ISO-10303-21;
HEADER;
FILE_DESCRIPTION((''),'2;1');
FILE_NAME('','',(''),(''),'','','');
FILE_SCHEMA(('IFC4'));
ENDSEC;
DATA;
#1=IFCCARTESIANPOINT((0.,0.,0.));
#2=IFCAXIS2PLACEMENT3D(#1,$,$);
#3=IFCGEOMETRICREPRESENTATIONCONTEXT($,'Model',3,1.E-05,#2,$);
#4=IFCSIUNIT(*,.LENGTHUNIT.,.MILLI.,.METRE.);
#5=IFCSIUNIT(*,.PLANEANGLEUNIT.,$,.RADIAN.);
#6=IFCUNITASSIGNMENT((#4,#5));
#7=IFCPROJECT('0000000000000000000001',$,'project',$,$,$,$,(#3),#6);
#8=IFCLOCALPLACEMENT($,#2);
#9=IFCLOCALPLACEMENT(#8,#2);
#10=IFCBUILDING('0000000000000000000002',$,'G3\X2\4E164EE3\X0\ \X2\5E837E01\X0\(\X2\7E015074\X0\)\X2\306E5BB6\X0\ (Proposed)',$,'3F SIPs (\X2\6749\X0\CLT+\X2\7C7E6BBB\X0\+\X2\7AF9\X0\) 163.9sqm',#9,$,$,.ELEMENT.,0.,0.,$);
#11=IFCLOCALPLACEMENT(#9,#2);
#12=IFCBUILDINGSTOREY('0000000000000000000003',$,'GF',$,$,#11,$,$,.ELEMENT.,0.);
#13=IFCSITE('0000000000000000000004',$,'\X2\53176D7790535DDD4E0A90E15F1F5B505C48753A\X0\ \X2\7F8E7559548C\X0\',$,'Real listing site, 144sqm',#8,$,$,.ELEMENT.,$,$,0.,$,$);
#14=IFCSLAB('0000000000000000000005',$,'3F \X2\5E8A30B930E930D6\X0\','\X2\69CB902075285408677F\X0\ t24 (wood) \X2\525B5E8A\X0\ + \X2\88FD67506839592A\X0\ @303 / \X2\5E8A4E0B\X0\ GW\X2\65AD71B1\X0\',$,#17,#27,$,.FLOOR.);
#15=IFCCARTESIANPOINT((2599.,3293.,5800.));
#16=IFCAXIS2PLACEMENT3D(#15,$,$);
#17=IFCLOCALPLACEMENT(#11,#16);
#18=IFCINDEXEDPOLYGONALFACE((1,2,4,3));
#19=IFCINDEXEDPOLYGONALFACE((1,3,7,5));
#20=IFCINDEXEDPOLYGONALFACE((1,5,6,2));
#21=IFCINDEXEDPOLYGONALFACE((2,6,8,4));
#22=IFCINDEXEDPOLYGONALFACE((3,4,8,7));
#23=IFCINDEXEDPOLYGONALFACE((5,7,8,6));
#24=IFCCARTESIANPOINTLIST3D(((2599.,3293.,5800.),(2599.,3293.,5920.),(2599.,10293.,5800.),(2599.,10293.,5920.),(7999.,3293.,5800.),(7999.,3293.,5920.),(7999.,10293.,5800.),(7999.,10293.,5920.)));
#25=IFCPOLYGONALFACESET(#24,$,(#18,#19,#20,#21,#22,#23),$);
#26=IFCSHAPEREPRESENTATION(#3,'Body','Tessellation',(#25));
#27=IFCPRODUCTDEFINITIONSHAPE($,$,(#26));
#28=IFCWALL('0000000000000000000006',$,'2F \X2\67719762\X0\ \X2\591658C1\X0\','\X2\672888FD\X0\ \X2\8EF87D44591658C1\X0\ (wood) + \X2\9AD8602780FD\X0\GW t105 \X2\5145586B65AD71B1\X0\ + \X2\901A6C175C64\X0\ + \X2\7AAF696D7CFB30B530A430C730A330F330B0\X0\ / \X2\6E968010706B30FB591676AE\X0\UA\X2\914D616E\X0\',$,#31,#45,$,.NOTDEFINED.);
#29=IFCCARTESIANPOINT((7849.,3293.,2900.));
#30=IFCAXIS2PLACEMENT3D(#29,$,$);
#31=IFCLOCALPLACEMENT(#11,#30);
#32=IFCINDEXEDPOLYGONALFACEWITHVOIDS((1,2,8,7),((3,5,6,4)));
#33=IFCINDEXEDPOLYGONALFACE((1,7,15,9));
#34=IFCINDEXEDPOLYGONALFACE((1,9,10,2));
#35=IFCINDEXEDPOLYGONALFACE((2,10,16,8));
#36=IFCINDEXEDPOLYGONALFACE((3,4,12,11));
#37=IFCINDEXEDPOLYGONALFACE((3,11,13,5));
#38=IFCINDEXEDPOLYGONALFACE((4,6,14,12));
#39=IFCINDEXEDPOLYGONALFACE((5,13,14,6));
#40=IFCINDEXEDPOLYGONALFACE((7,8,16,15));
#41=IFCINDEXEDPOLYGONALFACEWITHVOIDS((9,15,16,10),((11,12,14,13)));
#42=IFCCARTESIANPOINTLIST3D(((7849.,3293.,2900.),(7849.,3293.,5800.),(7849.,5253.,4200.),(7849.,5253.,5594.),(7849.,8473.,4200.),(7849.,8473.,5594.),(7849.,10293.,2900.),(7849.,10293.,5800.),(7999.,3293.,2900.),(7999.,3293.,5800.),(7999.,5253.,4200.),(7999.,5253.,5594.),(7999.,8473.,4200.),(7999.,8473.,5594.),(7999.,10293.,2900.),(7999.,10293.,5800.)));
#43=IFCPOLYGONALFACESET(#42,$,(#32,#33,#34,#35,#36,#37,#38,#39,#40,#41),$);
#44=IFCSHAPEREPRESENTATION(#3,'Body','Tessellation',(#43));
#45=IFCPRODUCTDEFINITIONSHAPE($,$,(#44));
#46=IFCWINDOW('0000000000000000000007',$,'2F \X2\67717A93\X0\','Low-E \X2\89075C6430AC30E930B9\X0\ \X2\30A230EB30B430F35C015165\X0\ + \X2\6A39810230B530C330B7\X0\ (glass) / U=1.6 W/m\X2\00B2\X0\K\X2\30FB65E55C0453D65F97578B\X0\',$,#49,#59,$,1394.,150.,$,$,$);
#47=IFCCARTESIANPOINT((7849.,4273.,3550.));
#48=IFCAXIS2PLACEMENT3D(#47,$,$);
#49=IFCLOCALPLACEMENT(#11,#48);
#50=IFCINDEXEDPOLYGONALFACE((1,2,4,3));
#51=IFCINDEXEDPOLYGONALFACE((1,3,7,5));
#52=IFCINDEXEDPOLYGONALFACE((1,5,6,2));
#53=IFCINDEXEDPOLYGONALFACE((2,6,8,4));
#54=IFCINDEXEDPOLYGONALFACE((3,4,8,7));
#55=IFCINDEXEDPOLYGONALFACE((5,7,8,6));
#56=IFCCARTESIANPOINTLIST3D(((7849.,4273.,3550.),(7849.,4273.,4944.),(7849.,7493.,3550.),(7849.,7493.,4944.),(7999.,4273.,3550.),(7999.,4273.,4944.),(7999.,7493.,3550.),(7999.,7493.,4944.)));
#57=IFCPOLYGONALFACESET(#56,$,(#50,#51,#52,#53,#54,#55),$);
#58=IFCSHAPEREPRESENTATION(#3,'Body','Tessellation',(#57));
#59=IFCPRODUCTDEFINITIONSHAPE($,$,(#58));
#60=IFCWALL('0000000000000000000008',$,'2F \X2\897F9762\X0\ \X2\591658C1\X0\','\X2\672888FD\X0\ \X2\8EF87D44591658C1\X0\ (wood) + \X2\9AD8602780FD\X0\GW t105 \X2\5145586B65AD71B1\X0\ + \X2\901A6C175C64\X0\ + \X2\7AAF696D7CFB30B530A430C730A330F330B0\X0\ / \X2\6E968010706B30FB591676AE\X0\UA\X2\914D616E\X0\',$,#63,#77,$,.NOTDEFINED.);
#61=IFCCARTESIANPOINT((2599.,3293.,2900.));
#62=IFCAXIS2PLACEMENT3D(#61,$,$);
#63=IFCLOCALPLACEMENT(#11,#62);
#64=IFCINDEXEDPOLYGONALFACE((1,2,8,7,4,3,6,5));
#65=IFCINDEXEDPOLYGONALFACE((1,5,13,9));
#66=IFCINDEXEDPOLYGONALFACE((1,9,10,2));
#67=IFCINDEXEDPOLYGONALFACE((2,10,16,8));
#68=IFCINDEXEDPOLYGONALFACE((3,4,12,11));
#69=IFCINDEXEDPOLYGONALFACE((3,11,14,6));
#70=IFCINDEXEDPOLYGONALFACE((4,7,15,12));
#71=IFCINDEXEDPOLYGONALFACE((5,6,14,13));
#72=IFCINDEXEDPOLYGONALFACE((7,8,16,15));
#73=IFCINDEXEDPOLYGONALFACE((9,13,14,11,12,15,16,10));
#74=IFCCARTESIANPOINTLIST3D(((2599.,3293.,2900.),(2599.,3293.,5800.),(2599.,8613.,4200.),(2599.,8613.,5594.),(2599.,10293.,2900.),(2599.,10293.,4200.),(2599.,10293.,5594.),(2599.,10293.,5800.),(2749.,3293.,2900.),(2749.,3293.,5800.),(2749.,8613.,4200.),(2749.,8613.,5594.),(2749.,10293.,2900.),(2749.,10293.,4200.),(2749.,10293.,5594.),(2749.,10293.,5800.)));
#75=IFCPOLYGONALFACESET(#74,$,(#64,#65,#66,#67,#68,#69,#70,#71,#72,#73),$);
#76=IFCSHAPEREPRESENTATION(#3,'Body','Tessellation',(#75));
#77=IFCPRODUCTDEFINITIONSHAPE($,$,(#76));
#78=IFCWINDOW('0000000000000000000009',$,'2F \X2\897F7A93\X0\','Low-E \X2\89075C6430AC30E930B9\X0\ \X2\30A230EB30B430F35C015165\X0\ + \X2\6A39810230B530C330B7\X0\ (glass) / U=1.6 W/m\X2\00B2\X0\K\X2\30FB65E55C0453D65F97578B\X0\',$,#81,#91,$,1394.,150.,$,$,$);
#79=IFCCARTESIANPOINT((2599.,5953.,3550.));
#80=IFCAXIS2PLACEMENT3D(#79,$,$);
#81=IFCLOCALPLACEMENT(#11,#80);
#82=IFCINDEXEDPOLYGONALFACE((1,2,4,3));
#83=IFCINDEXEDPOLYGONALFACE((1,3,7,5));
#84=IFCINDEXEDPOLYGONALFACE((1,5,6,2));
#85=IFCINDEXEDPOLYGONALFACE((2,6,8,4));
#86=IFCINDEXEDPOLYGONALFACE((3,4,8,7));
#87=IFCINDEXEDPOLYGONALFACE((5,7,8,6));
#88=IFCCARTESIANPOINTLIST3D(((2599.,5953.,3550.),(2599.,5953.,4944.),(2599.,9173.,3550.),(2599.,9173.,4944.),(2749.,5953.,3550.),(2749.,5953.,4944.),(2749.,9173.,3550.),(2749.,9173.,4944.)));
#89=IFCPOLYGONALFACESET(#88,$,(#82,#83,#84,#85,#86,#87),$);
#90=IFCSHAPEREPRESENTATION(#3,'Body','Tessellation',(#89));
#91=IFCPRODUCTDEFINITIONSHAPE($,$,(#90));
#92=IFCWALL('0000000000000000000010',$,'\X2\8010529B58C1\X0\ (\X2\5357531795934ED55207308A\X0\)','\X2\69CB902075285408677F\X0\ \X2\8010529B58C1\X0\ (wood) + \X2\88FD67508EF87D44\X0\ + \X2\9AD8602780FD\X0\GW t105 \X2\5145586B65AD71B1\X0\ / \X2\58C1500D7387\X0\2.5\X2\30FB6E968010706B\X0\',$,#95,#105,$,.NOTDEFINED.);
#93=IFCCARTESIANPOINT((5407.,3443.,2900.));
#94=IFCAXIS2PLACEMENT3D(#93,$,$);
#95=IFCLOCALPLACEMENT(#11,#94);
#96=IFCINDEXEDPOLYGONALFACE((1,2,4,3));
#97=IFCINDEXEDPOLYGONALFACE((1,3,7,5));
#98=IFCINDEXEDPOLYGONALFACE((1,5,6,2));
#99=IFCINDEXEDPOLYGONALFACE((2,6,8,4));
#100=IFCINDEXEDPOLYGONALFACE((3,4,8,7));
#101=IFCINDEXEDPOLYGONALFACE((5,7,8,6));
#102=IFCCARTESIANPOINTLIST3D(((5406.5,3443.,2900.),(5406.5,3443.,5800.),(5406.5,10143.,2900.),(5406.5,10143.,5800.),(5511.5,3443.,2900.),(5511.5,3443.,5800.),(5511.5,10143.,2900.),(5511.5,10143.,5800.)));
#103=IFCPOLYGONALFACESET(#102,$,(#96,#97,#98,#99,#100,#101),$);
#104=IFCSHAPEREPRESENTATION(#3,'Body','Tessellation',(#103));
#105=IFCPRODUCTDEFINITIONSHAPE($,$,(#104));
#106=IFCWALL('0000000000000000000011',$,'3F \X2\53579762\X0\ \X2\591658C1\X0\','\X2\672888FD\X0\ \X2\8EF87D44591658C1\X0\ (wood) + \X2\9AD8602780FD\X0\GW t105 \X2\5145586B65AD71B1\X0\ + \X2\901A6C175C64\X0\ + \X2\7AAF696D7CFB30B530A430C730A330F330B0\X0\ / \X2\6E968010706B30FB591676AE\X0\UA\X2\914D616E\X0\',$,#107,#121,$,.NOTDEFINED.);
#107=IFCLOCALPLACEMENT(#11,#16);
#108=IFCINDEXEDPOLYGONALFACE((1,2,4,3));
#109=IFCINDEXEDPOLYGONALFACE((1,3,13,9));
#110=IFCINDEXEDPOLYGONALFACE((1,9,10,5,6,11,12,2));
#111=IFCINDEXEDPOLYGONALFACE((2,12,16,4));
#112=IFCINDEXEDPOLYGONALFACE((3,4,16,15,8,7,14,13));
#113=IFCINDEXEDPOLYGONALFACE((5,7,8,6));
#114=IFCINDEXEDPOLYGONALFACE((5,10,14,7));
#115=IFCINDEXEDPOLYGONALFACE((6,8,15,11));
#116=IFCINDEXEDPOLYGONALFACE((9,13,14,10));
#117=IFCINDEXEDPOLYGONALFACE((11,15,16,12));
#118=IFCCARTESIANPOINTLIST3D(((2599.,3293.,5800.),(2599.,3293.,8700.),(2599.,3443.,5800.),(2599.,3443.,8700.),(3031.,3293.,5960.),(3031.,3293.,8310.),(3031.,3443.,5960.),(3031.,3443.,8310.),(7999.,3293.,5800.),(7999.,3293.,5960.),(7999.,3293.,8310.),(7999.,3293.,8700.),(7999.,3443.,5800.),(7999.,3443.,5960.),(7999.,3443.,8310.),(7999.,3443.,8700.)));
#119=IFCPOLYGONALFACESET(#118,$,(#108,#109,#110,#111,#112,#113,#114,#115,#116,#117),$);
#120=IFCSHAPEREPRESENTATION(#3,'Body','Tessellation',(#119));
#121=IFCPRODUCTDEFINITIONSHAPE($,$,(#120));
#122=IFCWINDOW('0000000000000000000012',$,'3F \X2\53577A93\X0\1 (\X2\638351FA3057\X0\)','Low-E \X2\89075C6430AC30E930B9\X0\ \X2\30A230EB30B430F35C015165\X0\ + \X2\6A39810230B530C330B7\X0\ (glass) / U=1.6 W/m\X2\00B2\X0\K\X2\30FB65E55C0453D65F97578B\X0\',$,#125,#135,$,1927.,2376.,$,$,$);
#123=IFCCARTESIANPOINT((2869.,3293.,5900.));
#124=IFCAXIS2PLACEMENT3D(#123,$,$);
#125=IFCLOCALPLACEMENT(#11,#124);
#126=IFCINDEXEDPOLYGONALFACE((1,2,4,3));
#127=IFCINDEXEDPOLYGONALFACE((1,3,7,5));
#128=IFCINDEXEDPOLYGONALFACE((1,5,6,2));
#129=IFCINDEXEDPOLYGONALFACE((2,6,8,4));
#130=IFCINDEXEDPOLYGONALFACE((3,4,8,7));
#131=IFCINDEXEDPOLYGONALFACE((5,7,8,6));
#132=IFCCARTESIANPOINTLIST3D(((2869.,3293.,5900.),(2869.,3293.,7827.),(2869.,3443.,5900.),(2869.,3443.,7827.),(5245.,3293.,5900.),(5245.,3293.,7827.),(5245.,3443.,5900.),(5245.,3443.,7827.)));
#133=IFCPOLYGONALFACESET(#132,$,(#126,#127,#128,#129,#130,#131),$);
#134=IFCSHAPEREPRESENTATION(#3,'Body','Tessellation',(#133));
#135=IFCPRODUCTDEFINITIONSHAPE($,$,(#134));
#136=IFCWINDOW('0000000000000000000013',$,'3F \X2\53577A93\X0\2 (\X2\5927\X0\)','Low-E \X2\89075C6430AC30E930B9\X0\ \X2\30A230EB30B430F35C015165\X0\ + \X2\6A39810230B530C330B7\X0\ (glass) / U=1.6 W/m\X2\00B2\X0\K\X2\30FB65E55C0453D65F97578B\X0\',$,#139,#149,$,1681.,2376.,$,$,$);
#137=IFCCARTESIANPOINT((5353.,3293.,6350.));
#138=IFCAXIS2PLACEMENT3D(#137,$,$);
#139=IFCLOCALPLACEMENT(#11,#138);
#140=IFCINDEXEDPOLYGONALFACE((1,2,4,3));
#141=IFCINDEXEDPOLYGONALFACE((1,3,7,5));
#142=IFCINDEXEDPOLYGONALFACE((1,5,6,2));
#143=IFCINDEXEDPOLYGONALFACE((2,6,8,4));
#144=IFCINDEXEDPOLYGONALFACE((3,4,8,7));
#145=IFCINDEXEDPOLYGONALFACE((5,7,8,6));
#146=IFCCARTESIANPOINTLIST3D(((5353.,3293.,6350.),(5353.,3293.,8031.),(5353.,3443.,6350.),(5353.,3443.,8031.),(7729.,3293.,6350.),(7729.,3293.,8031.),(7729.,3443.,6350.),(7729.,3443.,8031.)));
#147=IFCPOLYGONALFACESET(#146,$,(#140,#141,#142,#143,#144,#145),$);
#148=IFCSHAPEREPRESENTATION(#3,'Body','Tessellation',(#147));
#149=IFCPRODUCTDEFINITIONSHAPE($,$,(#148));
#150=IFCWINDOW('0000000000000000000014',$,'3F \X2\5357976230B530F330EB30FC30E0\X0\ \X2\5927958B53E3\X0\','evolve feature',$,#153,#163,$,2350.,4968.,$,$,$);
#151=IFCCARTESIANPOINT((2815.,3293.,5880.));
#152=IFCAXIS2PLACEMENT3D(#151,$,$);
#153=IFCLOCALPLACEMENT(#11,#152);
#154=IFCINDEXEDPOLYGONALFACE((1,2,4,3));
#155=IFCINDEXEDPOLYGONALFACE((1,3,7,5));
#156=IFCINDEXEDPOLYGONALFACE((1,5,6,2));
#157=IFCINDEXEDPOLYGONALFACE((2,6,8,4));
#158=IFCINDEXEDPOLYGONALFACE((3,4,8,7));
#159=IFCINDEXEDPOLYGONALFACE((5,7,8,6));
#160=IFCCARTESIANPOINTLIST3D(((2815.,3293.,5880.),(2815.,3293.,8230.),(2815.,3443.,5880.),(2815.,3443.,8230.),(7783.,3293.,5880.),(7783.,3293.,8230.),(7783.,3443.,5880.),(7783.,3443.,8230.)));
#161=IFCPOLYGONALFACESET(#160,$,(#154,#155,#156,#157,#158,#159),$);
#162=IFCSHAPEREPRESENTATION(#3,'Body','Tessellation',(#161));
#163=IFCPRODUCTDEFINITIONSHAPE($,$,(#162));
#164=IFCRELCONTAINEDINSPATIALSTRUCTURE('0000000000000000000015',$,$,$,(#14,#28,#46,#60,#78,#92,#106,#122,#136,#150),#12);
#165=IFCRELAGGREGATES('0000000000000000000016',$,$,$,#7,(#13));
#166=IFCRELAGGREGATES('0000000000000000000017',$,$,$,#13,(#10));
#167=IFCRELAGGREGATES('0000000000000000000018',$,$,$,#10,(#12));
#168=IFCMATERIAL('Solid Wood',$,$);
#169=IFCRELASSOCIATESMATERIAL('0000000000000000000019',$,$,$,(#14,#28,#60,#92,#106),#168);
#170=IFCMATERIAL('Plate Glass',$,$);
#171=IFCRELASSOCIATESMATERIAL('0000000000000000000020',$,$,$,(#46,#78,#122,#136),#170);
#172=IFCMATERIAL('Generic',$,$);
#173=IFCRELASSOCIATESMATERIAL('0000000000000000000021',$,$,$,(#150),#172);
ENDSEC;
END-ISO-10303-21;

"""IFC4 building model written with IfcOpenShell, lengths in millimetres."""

from ifc_helpers import new_model, si_unit, frame, frame_2d, origin, place, context, project, spatial, rectangle, extrude, material, element, fill, save


model = new_model("IFC4")

# Units and contexts
model_context = context("Model", 3, precision=1e-05, world=origin())
ifc_project = project(units=[si_unit("LENGTHUNIT", "METRE", prefix="MILLI"), si_unit("PLANEANGLEUNIT", "RADIAN")], contexts=[model_context])

# Site, building, storey
site_placement = place(None, origin())
site = spatial("IfcSite", under=ifc_project, at=site_placement, Name="北海道川上郡弟子屈町 美留和", ObjectType="Real listing site, 144sqm", CompositionType="ELEMENT", RefElevation=0.0)
building_placement = place(site_placement, origin())
building = spatial("IfcBuilding", under=site, at=building_placement, Name="G3世代 広縁(縁側)の家 (Proposed)", ObjectType="3F SIPs (杉CLT+籾殻+竹) 163.9sqm", CompositionType="ELEMENT", ElevationOfRefHeight=0.0, ElevationOfTerrain=0.0)
storey_placement = place(building_placement, origin())
storey = spatial("IfcBuildingStorey", under=building, at=storey_placement, Name="GF", CompositionType="ELEMENT", Elevation=0.0)

# Slab
ifc_material_1 = material(Name="Solid Wood")
slab_placement = place(storey_placement, frame((2599.0, 3293.0, 5800.0)))
element("IfcSlab", 1, at=slab_placement, inside=storey, material=ifc_material_1, Name="3F 床スラブ", Description="構造用合板 t24 (wood) 剛床 + 製材根太 @303 / 床下 GW断熱", PredefinedType="FLOOR", context=model_context, shape_type="SweptSolid", body=[
    extrude(rectangle(XDim=5400.0, YDim=7000.0, at=frame_2d((2700.0, 3500.0))), frame((2599.0, 3293.0, 5800.0)), (0.0, 0.0, 1.0), 120.0),
])

# Walls, openings, windows
wall_1_placement = place(storey_placement, frame((7849.0, 3293.0, 2900.0)))
wall_1 = element("IfcWall", 2, at=wall_1_placement, inside=storey, material=ifc_material_1, Name="2F 東面 外壁", Description="木製 軸組外壁 (wood) + 高性能GW t105 充填断熱 + 通気層 + 窯業系サイディング / 準耐火・外皮UA配慮", PredefinedType="NOTDEFINED", context=model_context, shape_type="SweptSolid", body=[
    extrude(rectangle(XDim=150.0, YDim=7000.0, at=frame_2d((75.0, 3500.0))), frame((7849.0, 3293.0, 2900.0)), (0.0, 0.0, 1.0), 2900.0),
])
opening_1_placement = place(storey_placement, frame((7849.0, 4273.0, 3550.0)))
opening_1 = element("IfcOpeningElement", 3, at=opening_1_placement, cuts=wall_1, PredefinedType="NOTDEFINED", context=model_context, shape_type="SweptSolid", body=[
    extrude(rectangle(XDim=150.0, YDim=3220.0, at=frame_2d((75.0, 1610.0))), frame((7849.0, 4273.0, 3550.0)), (0.0, 0.0, 1.0), 1394.0),
])
ifc_material_2 = material(Name="Plate Glass")
window_1_placement = place(storey_placement, frame((7849.0, 4273.0, 3550.0)))
window_1 = element("IfcWindow", 4, at=window_1_placement, inside=storey, material=ifc_material_2, Name="2F 東窓", Description="Low-E 複層ガラス アルゴン封入 + 樹脂サッシ (glass) / U=1.6 W/m²K・日射取得型", OverallHeight=1394.0, OverallWidth=150.0, context=model_context, shape_type="SweptSolid", body=[
    extrude(rectangle(XDim=150.0, YDim=3220.0, at=frame_2d((75.0, 1610.0))), frame((7849.0, 4273.0, 3550.0)), (0.0, 0.0, 1.0), 1394.0),
])
fill(opening_1, window_1)
wall_2_placement = place(storey_placement, frame((2599.0, 3293.0, 2900.0)))
wall_2 = element("IfcWall", 5, at=wall_2_placement, inside=storey, material=ifc_material_1, Name="2F 西面 外壁", Description="木製 軸組外壁 (wood) + 高性能GW t105 充填断熱 + 通気層 + 窯業系サイディング / 準耐火・外皮UA配慮", PredefinedType="NOTDEFINED", context=model_context, shape_type="SweptSolid", body=[
    extrude(rectangle(XDim=150.0, YDim=7000.0, at=frame_2d((75.0, 3500.0))), frame((2599.0, 3293.0, 2900.0)), (0.0, 0.0, 1.0), 2900.0),
])
opening_2_placement = place(storey_placement, frame((2599.0, 5953.0, 3550.0)))
opening_2 = element("IfcOpeningElement", 6, at=opening_2_placement, cuts=wall_2, PredefinedType="NOTDEFINED", context=model_context, shape_type="SweptSolid", body=[
    extrude(rectangle(XDim=150.0, YDim=3220.0, at=frame_2d((75.0, 1610.0))), frame((2599.0, 5953.0, 3550.0)), (0.0, 0.0, 1.0), 1394.0),
])
window_2_placement = place(storey_placement, frame((2599.0, 5953.0, 3550.0)))
window_2 = element("IfcWindow", 7, at=window_2_placement, inside=storey, material=ifc_material_2, Name="2F 西窓", Description="Low-E 複層ガラス アルゴン封入 + 樹脂サッシ (glass) / U=1.6 W/m²K・日射取得型", OverallHeight=1394.0, OverallWidth=150.0, context=model_context, shape_type="SweptSolid", body=[
    extrude(rectangle(XDim=150.0, YDim=3220.0, at=frame_2d((75.0, 1610.0))), frame((2599.0, 5953.0, 3550.0)), (0.0, 0.0, 1.0), 1394.0),
])
fill(opening_2, window_2)

# Wall
wall_3_placement = place(storey_placement, frame((5407.0, 3443.0, 2900.0)))
element("IfcWall", 8, at=wall_3_placement, inside=storey, material=ifc_material_1, Name="耐力壁 (南北間仕切り)", Description="構造用合板 耐力壁 (wood) + 製材軸組 + 高性能GW t105 充填断熱 / 壁倍率2.5・準耐火", PredefinedType="NOTDEFINED", context=model_context, shape_type="SweptSolid", body=[
    extrude(rectangle(XDim=105.0, YDim=6700.0, at=frame_2d((52.0, 3350.0))), frame((5407.0, 3443.0, 2900.0)), (0.0, 0.0, 1.0), 2900.0),
])

# Wall, openings, windows
wall_4_placement = place(storey_placement, frame((2599.0, 3293.0, 5800.0)))
wall_4 = element("IfcWall", 9, at=wall_4_placement, inside=storey, material=ifc_material_1, Name="3F 南面 外壁", Description="木製 軸組外壁 (wood) + 高性能GW t105 充填断熱 + 通気層 + 窯業系サイディング / 準耐火・外皮UA配慮", PredefinedType="NOTDEFINED", context=model_context, shape_type="SweptSolid", body=[
    extrude(rectangle(XDim=5400.0, YDim=150.0, at=frame_2d((2700.0, 75.0))), frame((2599.0, 3293.0, 5800.0)), (0.0, 0.0, 1.0), 2900.0),
])
opening_3_placement = place(storey_placement, frame((2869.0, 3293.0, 5900.0)))
opening_3 = element("IfcOpeningElement", 10, at=opening_3_placement, cuts=wall_4, PredefinedType="NOTDEFINED", context=model_context, shape_type="SweptSolid", body=[
    extrude(rectangle(XDim=2376.0, YDim=150.0, at=frame_2d((1188.0, 75.0))), frame((2869.0, 3293.0, 5900.0)), (0.0, 0.0, 1.0), 1927.0),
])
opening_4_placement = place(storey_placement, frame((5353.0, 3293.0, 6350.0)))
opening_4 = element("IfcOpeningElement", 11, at=opening_4_placement, cuts=wall_4, PredefinedType="NOTDEFINED", context=model_context, shape_type="SweptSolid", body=[
    extrude(rectangle(XDim=2376.0, YDim=150.0, at=frame_2d((1188.0, 75.0))), frame((5353.0, 3293.0, 6350.0)), (0.0, 0.0, 1.0), 1681.0),
])
opening_5_placement = place(storey_placement, frame((2815.0, 3293.0, 5880.0)))
opening_5 = element("IfcOpeningElement", 12, at=opening_5_placement, cuts=wall_4, PredefinedType="NOTDEFINED", context=model_context, shape_type="SweptSolid", body=[
    extrude(rectangle(XDim=4968.0, YDim=150.0, at=frame_2d((2484.0, 75.0))), frame((2815.0, 3293.0, 5880.0)), (0.0, 0.0, 1.0), 2350.0),
])
window_3_placement = place(storey_placement, frame((2869.0, 3293.0, 5900.0)))
window_3 = element("IfcWindow", 13, at=window_3_placement, inside=storey, material=ifc_material_2, Name="3F 南窓1 (掃出し)", Description="Low-E 複層ガラス アルゴン封入 + 樹脂サッシ (glass) / U=1.6 W/m²K・日射取得型", OverallHeight=1927.0, OverallWidth=2376.0, context=model_context, shape_type="SweptSolid", body=[
    extrude(rectangle(XDim=2376.0, YDim=150.0, at=frame_2d((1188.0, 75.0))), frame((2869.0, 3293.0, 5900.0)), (0.0, 0.0, 1.0), 1927.0),
])
fill(opening_3, window_3)
window_4_placement = place(storey_placement, frame((5353.0, 3293.0, 6350.0)))
window_4 = element("IfcWindow", 14, at=window_4_placement, inside=storey, material=ifc_material_2, Name="3F 南窓2 (大)", Description="Low-E 複層ガラス アルゴン封入 + 樹脂サッシ (glass) / U=1.6 W/m²K・日射取得型", OverallHeight=1681.0, OverallWidth=2376.0, context=model_context, shape_type="SweptSolid", body=[
    extrude(rectangle(XDim=2376.0, YDim=150.0, at=frame_2d((1188.0, 75.0))), frame((5353.0, 3293.0, 6350.0)), (0.0, 0.0, 1.0), 1681.0),
])
fill(opening_4, window_4)
ifc_material_3 = material(Name="Generic")
window_5_placement = place(storey_placement, frame((2815.0, 3293.0, 5880.0)))
window_5 = element("IfcWindow", 15, at=window_5_placement, inside=storey, material=ifc_material_3, Name="3F 南面サンルーム 大開口", Description="evolve feature", OverallHeight=2350.0, OverallWidth=4968.0, context=model_context, shape_type="SweptSolid", body=[
    extrude(rectangle(XDim=4968.0, YDim=150.0, at=frame_2d((2484.0, 75.0))), frame((2815.0, 3293.0, 5880.0)), (0.0, 0.0, 1.0), 2350.0),
])
fill(opening_5, window_5)

save(model, "model.ifc")
